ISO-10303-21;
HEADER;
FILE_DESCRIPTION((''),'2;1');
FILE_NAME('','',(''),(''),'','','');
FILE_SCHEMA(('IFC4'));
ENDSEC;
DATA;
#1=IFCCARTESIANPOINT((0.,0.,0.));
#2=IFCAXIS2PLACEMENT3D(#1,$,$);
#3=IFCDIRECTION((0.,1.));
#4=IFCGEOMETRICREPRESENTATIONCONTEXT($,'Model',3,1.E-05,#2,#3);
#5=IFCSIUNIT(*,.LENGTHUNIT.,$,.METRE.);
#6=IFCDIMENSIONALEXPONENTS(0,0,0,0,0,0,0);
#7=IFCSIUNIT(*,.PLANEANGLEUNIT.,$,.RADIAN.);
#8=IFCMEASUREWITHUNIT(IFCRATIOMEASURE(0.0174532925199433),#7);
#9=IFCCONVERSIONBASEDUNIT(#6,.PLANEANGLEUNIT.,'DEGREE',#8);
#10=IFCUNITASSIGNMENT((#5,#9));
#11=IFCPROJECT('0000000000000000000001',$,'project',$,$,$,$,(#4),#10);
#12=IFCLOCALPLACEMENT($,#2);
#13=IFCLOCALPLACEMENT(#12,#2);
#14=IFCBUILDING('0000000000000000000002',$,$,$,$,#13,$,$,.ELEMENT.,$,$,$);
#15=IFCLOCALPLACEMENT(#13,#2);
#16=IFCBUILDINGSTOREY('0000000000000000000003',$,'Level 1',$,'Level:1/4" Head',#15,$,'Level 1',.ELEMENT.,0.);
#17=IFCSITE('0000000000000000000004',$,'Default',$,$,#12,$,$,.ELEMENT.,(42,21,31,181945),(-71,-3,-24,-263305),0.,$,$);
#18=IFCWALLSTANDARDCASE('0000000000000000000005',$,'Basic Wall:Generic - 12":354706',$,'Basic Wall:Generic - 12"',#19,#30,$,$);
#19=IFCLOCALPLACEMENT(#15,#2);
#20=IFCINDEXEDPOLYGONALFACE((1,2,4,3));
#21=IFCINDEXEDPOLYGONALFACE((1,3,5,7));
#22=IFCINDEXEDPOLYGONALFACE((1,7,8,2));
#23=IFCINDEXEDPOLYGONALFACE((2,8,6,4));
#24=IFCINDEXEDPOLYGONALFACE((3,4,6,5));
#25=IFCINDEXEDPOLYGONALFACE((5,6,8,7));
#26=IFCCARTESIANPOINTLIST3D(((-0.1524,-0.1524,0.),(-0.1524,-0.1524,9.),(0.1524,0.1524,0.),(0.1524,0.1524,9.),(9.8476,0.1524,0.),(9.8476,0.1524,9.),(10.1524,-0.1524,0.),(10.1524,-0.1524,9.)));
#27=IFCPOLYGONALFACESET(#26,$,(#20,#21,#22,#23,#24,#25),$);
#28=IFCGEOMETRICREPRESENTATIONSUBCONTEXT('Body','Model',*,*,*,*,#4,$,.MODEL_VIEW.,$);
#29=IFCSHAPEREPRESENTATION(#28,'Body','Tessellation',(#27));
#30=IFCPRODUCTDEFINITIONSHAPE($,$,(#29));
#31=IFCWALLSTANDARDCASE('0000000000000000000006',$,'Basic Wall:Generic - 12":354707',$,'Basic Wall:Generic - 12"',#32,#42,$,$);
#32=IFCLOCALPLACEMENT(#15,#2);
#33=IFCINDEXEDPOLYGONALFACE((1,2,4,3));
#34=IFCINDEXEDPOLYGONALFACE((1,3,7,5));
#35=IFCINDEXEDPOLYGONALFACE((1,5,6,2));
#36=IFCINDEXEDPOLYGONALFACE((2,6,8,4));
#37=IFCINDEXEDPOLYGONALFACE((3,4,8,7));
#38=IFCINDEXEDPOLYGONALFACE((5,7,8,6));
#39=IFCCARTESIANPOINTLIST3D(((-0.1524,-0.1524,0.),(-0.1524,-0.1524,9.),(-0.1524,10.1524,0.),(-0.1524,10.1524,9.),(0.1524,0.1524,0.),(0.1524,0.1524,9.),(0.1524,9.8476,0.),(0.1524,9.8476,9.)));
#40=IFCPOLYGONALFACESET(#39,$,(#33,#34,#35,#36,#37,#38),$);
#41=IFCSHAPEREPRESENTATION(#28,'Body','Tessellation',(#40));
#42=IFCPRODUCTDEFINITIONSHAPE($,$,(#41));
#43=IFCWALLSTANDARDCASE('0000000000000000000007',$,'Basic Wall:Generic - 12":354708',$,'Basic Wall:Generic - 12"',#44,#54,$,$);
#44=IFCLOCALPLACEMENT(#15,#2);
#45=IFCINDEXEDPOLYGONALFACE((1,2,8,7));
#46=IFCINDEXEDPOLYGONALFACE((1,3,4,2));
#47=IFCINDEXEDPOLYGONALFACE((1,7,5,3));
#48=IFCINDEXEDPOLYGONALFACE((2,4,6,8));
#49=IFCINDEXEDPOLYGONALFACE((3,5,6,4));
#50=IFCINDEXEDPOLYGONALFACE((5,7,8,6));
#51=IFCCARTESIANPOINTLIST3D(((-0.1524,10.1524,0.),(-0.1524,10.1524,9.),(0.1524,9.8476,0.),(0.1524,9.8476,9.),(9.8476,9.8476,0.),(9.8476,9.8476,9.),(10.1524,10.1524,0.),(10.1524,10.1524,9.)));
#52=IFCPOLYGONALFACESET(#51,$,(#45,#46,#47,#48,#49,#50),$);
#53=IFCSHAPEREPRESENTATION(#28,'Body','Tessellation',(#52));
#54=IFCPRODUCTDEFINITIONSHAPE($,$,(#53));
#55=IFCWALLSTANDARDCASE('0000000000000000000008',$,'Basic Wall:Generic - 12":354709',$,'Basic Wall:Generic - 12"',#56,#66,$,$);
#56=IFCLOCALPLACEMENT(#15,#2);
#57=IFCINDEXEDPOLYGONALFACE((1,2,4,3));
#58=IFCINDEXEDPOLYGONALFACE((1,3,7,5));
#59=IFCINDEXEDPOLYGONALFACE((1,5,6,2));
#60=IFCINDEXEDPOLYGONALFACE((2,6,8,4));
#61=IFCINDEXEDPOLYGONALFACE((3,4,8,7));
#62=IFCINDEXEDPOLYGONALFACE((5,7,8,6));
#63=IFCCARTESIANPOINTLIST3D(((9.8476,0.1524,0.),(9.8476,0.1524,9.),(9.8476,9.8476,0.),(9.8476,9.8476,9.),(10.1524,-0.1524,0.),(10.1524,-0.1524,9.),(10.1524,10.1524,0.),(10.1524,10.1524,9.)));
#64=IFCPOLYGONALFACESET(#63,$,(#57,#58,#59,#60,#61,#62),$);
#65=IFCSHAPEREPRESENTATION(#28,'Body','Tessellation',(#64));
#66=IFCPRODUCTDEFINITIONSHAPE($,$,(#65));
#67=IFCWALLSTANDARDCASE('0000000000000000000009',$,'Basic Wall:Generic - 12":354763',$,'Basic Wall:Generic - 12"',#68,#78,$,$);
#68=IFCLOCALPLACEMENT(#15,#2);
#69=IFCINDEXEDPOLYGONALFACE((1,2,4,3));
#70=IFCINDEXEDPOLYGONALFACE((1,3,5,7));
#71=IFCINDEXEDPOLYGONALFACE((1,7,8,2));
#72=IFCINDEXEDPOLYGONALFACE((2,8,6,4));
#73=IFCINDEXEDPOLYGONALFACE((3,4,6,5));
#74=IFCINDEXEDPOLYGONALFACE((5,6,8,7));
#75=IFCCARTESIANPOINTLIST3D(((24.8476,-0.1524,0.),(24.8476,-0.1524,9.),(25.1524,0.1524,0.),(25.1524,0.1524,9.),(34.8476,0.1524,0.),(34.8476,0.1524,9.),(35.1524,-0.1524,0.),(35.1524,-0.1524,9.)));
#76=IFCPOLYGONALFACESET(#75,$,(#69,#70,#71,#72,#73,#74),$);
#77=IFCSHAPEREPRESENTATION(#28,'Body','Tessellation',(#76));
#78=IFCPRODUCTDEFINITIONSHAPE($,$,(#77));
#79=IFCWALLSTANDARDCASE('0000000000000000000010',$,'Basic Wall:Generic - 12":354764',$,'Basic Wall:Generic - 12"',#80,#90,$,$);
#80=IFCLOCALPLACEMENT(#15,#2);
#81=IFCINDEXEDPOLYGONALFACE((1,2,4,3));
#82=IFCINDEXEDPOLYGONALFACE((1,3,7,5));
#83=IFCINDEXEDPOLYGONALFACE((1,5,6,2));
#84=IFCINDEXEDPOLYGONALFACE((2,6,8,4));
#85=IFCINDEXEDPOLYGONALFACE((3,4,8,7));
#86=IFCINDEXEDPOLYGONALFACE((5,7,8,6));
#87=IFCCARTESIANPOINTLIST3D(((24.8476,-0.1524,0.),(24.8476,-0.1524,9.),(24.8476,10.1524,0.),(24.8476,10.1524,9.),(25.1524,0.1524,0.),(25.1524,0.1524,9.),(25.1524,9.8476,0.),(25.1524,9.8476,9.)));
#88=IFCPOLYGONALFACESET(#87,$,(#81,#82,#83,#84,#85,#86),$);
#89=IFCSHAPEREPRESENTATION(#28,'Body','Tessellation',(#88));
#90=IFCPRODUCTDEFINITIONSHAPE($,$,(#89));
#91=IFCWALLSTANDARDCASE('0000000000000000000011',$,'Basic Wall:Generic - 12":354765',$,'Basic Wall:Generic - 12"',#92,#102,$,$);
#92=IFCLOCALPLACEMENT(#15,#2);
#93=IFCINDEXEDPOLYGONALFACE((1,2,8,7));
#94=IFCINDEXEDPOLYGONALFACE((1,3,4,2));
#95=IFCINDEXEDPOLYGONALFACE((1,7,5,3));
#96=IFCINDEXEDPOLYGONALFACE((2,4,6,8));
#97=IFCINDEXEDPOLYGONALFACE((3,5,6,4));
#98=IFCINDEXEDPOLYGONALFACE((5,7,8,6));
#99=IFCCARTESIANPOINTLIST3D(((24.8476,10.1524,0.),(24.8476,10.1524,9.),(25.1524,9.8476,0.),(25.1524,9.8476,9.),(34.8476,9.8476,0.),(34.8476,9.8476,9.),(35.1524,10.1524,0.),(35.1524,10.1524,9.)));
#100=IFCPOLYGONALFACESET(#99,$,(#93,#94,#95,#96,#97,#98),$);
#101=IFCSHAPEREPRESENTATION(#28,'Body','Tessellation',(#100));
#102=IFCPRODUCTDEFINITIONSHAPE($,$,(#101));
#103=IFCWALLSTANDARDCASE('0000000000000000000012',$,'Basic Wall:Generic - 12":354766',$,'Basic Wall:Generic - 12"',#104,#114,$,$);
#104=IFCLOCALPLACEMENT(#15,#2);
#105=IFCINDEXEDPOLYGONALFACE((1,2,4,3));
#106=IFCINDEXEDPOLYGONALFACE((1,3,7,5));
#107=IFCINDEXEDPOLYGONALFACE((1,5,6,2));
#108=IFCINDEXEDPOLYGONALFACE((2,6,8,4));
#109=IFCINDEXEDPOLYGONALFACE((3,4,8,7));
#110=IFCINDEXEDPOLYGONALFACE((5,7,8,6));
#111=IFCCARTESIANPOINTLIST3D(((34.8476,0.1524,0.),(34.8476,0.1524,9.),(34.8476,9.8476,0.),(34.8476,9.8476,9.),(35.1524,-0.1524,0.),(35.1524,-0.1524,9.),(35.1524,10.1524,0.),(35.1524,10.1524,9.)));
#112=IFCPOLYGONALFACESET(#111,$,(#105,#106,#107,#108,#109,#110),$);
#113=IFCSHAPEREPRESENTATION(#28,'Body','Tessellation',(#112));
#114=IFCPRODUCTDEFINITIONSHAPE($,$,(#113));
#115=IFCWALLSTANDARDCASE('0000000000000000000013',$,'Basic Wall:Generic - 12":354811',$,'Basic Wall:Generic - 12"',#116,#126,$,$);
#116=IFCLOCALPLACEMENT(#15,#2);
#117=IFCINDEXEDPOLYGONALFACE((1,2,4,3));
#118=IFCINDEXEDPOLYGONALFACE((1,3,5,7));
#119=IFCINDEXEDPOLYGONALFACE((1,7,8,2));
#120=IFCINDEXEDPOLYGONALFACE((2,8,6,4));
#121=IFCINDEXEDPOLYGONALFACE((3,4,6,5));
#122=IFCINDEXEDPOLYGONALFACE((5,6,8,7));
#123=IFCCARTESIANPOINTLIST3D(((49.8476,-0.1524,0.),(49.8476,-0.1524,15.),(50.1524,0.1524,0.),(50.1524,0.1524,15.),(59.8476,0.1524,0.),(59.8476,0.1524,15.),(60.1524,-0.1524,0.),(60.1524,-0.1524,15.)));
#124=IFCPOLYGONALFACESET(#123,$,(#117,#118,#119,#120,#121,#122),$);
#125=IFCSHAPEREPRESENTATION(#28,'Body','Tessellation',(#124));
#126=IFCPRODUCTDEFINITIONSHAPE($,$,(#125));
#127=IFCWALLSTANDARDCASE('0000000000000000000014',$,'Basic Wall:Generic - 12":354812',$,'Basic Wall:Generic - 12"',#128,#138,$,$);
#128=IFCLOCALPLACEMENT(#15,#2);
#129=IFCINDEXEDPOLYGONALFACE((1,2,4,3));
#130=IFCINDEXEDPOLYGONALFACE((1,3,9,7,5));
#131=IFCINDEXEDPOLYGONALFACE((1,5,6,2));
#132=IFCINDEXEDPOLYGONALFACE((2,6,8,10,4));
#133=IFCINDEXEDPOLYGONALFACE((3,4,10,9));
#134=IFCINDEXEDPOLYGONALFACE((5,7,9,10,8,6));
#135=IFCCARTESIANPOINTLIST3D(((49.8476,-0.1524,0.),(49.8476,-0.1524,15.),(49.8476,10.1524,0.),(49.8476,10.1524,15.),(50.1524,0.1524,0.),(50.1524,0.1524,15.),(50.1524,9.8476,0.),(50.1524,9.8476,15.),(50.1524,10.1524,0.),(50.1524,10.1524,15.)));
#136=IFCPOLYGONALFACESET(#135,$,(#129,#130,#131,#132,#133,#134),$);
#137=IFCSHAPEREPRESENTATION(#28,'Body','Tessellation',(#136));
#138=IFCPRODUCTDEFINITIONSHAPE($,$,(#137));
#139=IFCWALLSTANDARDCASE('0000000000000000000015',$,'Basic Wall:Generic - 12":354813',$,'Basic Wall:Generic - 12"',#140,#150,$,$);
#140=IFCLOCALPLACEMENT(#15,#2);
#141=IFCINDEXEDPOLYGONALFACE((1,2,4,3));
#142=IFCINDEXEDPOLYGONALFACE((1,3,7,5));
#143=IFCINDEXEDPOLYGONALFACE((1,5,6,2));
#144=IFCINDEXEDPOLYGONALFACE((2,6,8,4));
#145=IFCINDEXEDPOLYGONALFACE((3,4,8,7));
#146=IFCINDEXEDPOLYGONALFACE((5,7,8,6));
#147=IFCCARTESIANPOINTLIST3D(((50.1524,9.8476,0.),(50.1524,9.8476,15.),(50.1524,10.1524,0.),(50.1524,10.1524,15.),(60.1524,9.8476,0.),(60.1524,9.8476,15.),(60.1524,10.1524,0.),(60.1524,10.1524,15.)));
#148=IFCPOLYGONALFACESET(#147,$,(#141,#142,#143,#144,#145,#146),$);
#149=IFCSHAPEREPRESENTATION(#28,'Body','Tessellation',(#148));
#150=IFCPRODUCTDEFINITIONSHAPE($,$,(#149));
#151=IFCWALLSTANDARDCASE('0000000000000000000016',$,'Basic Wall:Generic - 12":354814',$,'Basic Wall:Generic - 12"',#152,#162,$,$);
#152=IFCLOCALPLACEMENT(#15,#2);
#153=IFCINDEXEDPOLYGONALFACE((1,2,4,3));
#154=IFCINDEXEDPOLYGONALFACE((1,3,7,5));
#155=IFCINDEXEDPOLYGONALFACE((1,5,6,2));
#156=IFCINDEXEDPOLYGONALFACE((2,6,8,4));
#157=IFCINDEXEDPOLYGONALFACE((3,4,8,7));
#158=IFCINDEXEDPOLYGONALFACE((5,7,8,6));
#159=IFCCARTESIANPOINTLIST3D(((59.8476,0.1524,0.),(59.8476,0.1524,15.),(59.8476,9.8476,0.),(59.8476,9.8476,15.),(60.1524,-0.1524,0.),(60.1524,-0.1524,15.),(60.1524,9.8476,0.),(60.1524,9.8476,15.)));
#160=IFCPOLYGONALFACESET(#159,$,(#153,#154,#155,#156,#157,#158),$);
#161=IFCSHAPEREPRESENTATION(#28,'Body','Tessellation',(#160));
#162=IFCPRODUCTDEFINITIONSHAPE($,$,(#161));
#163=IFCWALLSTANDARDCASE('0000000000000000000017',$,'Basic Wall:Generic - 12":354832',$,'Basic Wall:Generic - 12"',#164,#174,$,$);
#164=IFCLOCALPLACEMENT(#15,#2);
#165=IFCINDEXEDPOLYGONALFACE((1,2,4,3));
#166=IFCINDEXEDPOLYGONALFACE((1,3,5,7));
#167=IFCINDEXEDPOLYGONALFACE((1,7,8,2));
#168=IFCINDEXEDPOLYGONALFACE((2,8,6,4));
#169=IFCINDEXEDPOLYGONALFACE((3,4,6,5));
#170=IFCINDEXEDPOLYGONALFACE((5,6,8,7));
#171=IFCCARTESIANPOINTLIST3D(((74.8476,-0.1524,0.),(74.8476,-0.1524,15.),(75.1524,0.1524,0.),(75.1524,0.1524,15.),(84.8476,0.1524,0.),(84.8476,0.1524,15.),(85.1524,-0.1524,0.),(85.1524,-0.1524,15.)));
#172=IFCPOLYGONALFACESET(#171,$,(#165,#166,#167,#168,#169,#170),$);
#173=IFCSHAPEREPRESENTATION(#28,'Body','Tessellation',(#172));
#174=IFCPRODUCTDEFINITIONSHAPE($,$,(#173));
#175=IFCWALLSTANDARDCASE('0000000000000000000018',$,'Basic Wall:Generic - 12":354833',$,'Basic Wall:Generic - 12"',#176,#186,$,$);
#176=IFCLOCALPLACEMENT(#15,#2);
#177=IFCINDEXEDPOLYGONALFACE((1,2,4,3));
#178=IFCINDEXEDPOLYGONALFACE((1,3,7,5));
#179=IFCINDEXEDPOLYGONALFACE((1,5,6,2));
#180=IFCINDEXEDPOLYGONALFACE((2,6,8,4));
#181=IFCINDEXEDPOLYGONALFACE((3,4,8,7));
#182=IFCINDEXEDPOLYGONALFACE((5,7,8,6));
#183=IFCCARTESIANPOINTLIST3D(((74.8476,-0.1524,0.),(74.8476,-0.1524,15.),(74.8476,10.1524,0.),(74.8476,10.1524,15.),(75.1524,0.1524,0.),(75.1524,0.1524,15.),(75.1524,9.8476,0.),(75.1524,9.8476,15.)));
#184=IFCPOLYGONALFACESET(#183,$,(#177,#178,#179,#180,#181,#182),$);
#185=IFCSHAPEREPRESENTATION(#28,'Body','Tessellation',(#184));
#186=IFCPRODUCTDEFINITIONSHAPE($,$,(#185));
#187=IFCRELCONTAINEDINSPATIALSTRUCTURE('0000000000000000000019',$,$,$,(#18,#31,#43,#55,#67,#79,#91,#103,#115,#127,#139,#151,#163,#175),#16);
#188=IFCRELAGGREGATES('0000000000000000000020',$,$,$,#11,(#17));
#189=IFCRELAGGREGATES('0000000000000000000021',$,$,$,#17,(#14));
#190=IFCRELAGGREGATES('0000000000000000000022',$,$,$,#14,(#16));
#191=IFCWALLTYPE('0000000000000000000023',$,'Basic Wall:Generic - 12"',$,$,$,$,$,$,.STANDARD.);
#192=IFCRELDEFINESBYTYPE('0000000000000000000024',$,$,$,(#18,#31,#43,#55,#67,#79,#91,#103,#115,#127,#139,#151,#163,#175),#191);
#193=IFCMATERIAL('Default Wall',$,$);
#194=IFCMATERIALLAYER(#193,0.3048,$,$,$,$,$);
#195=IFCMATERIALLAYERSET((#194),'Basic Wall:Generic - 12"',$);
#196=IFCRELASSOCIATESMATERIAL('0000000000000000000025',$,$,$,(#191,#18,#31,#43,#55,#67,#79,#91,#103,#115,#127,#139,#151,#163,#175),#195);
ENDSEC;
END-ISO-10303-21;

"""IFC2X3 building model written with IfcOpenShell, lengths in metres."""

from ifc_helpers import new_model, entity, si_unit, converted_unit, direction, frame, frame_2d, origin, place, context, subcontext, project, spatial, polyline, rectangle, outline, extrude, material, layer, layer_set, layer_usage, type_object, element, save


model = new_model("IFC2X3")

# Units and contexts
model_context = context("Model", 3, precision=1e-05, world=origin(), true_north=direction((0.0, 1.0)))
body_context = subcontext(model_context, "Body", "Model", "MODEL_VIEW")
ifc_project = project(units=[si_unit("LENGTHUNIT", "METRE"), converted_unit("PLANEANGLEUNIT", "DEGREE", entity("IfcRatioMeasure", 0.0174532925199433), si_unit("PLANEANGLEUNIT", "RADIAN"), dimensions=[0, 0, 0, 0, 0, 0, 0])], contexts=[model_context])

# Site, building, storey
site_placement = place(None, origin())
site = spatial("IfcSite", under=ifc_project, at=site_placement, Name="Default", CompositionType="ELEMENT", RefLatitude=(42, 21, 31, 181945), RefLongitude=(-71, -3, -24, -263305), RefElevation=0.0)
building_placement = place(site_placement, origin())
building = spatial("IfcBuilding", under=site, at=building_placement, CompositionType="ELEMENT")
storey_placement = place(building_placement, origin())
storey = spatial("IfcBuildingStorey", under=building, at=storey_placement, Name="Level 1", ObjectType="Level:1/4\" Head", LongName="Level 1", CompositionType="ELEMENT", Elevation=0.0)

# Walls
ifc_material = material(Name="Default Wall")
ifc_layer = layer(ifc_material, 0.3048)
ifc_layer_set = layer_set([ifc_layer], Name="Basic Wall:Generic - 12\"")
ifc_layer_usage_1 = layer_usage(ifc_layer_set, "AXIS2", "NEGATIVE", 0.1524)
wall_type = type_object("IfcWallType", Name="Basic Wall:Generic - 12\"", PredefinedType="STANDARD", material=ifc_layer_set)
wall_1_placement = place(storey_placement, frame((-0.1524, 0.0, 0.0)))
element("IfcWallStandardCase", 1, at=wall_1_placement, inside=storey, type_object=wall_type, material=ifc_layer_usage_1, Name="Basic Wall:Generic - 12\":354706", ObjectType="Basic Wall:Generic - 12\"", context=body_context, shape_type="SweptSolid", body=[
    extrude(outline(polyline([(10.3048, -0.1524), (10.0, 0.1524), (0.3048, 0.1524), (0.0, -0.1524), (10.3048, -0.1524)])), origin(), (0.0, 0.0, 1.0), 9.0),
])
ifc_layer_usage_2 = layer_usage(ifc_layer_set, "AXIS2", "NEGATIVE", 0.1524)
wall_2_placement = place(storey_placement, frame((0.0, 10.1524, 0.0), z_axis=(0.0, 0.0, 1.0), x_axis=(0.0, -1.0, 0.0)))
element("IfcWallStandardCase", 2, at=wall_2_placement, inside=storey, type_object=wall_type, material=ifc_layer_usage_2, Name="Basic Wall:Generic - 12\":354707", ObjectType="Basic Wall:Generic - 12\"", context=body_context, shape_type="SweptSolid", body=[
    extrude(outline(polyline([(10.3048, -0.1524), (10.0, 0.1524), (0.3048, 0.1524), (0.0, -0.1524), (10.3048, -0.1524)])), origin(), (0.0, 0.0, 1.0), 9.0),
])
ifc_layer_usage_3 = layer_usage(ifc_layer_set, "AXIS2", "NEGATIVE", 0.1524)
wall_3_placement = place(storey_placement, frame((10.1524, 10.0, 0.0), z_axis=(0.0, 0.0, 1.0), x_axis=(-1.0, 0.0, 0.0)))
element("IfcWallStandardCase", 3, at=wall_3_placement, inside=storey, type_object=wall_type, material=ifc_layer_usage_3, Name="Basic Wall:Generic - 12\":354708", ObjectType="Basic Wall:Generic - 12\"", context=body_context, shape_type="SweptSolid", body=[
    extrude(outline(polyline([(10.3048, -0.1524), (10.0, 0.1524), (0.3048, 0.1524), (0.0, -0.1524), (10.3048, -0.1524)])), origin(), (0.0, 0.0, 1.0), 9.0),
])
ifc_layer_usage_4 = layer_usage(ifc_layer_set, "AXIS2", "NEGATIVE", 0.1524)
wall_4_placement = place(storey_placement, frame((10.0, -0.1524, 0.0), z_axis=(0.0, 0.0, 1.0), x_axis=(0.0, 1.0, 0.0)))
element("IfcWallStandardCase", 4, at=wall_4_placement, inside=storey, type_object=wall_type, material=ifc_layer_usage_4, Name="Basic Wall:Generic - 12\":354709", ObjectType="Basic Wall:Generic - 12\"", context=body_context, shape_type="SweptSolid", body=[
    extrude(outline(polyline([(10.3048, -0.1524), (10.0, 0.1524), (0.3048, 0.1524), (0.0, -0.1524), (10.3048, -0.1524)])), origin(), (0.0, 0.0, 1.0), 9.0),
])
ifc_layer_usage_5 = layer_usage(ifc_layer_set, "AXIS2", "NEGATIVE", 0.1524)
wall_5_placement = place(storey_placement, frame((24.8476, 0.0, 0.0)))
element("IfcWallStandardCase", 5, at=wall_5_placement, inside=storey, type_object=wall_type, material=ifc_layer_usage_5, Name="Basic Wall:Generic - 12\":354763", ObjectType="Basic Wall:Generic - 12\"", context=body_context, shape_type="SweptSolid", body=[
    extrude(outline(polyline([(10.3048, -0.1524), (10.0, 0.1524), (0.3048, 0.1524), (0.0, -0.1524), (10.3048, -0.1524)])), origin(), (0.0, 0.0, 1.0), 9.0),
])
ifc_layer_usage_6 = layer_usage(ifc_layer_set, "AXIS2", "NEGATIVE", 0.1524)
wall_6_placement = place(storey_placement, frame((25.0, 10.1524, 0.0), z_axis=(0.0, 0.0, 1.0), x_axis=(0.0, -1.0, 0.0)))
element("IfcWallStandardCase", 6, at=wall_6_placement, inside=storey, type_object=wall_type, material=ifc_layer_usage_6, Name="Basic Wall:Generic - 12\":354764", ObjectType="Basic Wall:Generic - 12\"", context=body_context, shape_type="SweptSolid", body=[
    extrude(outline(polyline([(10.3048, -0.1524), (10.0, 0.1524), (0.3048, 0.1524), (0.0, -0.1524), (10.3048, -0.1524)])), origin(), (0.0, 0.0, 1.0), 9.0),
])
ifc_layer_usage_7 = layer_usage(ifc_layer_set, "AXIS2", "NEGATIVE", 0.1524)
wall_7_placement = place(storey_placement, frame((35.1524, 10.0, 0.0), z_axis=(0.0, 0.0, 1.0), x_axis=(-1.0, 0.0, 0.0)))
element("IfcWallStandardCase", 7, at=wall_7_placement, inside=storey, type_object=wall_type, material=ifc_layer_usage_7, Name="Basic Wall:Generic - 12\":354765", ObjectType="Basic Wall:Generic - 12\"", context=body_context, shape_type="SweptSolid", body=[
    extrude(outline(polyline([(10.3048, -0.1524), (10.0, 0.1524), (0.3048, 0.1524), (0.0, -0.1524), (10.3048, -0.1524)])), origin(), (0.0, 0.0, 1.0), 9.0),
])
ifc_layer_usage_8 = layer_usage(ifc_layer_set, "AXIS2", "NEGATIVE", 0.1524)
wall_8_placement = place(storey_placement, frame((35.0, -0.1524, 0.0), z_axis=(0.0, 0.0, 1.0), x_axis=(0.0, 1.0, 0.0)))
element("IfcWallStandardCase", 8, at=wall_8_placement, inside=storey, type_object=wall_type, material=ifc_layer_usage_8, Name="Basic Wall:Generic - 12\":354766", ObjectType="Basic Wall:Generic - 12\"", context=body_context, shape_type="SweptSolid", body=[
    extrude(outline(polyline([(10.3048, -0.1524), (10.0, 0.1524), (0.3048, 0.1524), (0.0, -0.1524), (10.3048, -0.1524)])), origin(), (0.0, 0.0, 1.0), 9.0),
])
ifc_layer_usage_9 = layer_usage(ifc_layer_set, "AXIS2", "NEGATIVE", 0.1524)
wall_9_placement = place(storey_placement, frame((49.8476, 0.0, 0.0)))
element("IfcWallStandardCase", 9, at=wall_9_placement, inside=storey, type_object=wall_type, material=ifc_layer_usage_9, Name="Basic Wall:Generic - 12\":354811", ObjectType="Basic Wall:Generic - 12\"", context=body_context, shape_type="SweptSolid", body=[
    extrude(outline(polyline([(10.3048, -0.1524), (10.0, 0.1524), (0.3048, 0.1524), (0.0, -0.1524), (10.3048, -0.1524)])), origin(), (0.0, 0.0, 1.0), 15.0),
])
ifc_layer_usage_10 = layer_usage(ifc_layer_set, "AXIS2", "NEGATIVE", 0.1524)
wall_10_placement = place(storey_placement, frame((50.0, 10.1524, 0.0), z_axis=(0.0, 0.0, 1.0), x_axis=(0.0, -1.0, 0.0)))
element("IfcWallStandardCase", 10, at=wall_10_placement, inside=storey, type_object=wall_type, material=ifc_layer_usage_10, Name="Basic Wall:Generic - 12\":354812", ObjectType="Basic Wall:Generic - 12\"", context=body_context, shape_type="SweptSolid", body=[
    extrude(outline(polyline([(10.3048, -0.1524), (10.0, 0.1524), (0.3048, 0.1524), (0.0, 0.1524), (0.0, -0.1524), (10.3048, -0.1524)])), origin(), (0.0, 0.0, 1.0), 15.0),
])
ifc_layer_usage_11 = layer_usage(ifc_layer_set, "AXIS2", "NEGATIVE", 0.1524)
wall_11_placement = place(storey_placement, frame((60.1524, 10.0, 0.0), z_axis=(0.0, 0.0, 1.0), x_axis=(-1.0, 0.0, 0.0)))
element("IfcWallStandardCase", 11, at=wall_11_placement, inside=storey, type_object=wall_type, material=ifc_layer_usage_11, Name="Basic Wall:Generic - 12\":354813", ObjectType="Basic Wall:Generic - 12\"", context=body_context, shape_type="SweptSolid", body=[
    extrude(rectangle(XDim=10.0, YDim=0.3048, at=frame_2d((5.0, 0.0), x_axis=(-1.0, 0.0))), origin(), (0.0, 0.0, 1.0), 15.0),
])
ifc_layer_usage_12 = layer_usage(ifc_layer_set, "AXIS2", "NEGATIVE", 0.1524)
wall_12_placement = place(storey_placement, frame((60.0, -0.1524, 0.0), z_axis=(0.0, 0.0, 1.0), x_axis=(0.0, 1.0, 0.0)))
element("IfcWallStandardCase", 12, at=wall_12_placement, inside=storey, type_object=wall_type, material=ifc_layer_usage_12, Name="Basic Wall:Generic - 12\":354814", ObjectType="Basic Wall:Generic - 12\"", context=body_context, shape_type="SweptSolid", body=[
    extrude(outline(polyline([(10.0, -0.1524), (10.0, 0.1524), (0.3048, 0.1524), (0.0, -0.1524), (10.0, -0.1524)])), origin(), (0.0, 0.0, 1.0), 15.0),
])
ifc_layer_usage_13 = layer_usage(ifc_layer_set, "AXIS2", "NEGATIVE", 0.1524)
wall_13_placement = place(storey_placement, frame((74.8476, 0.0, 0.0)))
element("IfcWallStandardCase", 13, at=wall_13_placement, inside=storey, type_object=wall_type, material=ifc_layer_usage_13, Name="Basic Wall:Generic - 12\":354832", ObjectType="Basic Wall:Generic - 12\"", context=body_context, shape_type="SweptSolid", body=[
    extrude(outline(polyline([(10.3048, -0.1524), (10.0, 0.1524), (0.3048, 0.1524), (0.0, -0.1524), (10.3048, -0.1524)])), origin(), (0.0, 0.0, 1.0), 15.0),
])
ifc_layer_usage_14 = layer_usage(ifc_layer_set, "AXIS2", "NEGATIVE", 0.1524)
wall_14_placement = place(storey_placement, frame((75.0, 10.1524, 0.0), z_axis=(0.0, 0.0, 1.0), x_axis=(0.0, -1.0, 0.0)))
element("IfcWallStandardCase", 14, at=wall_14_placement, inside=storey, type_object=wall_type, material=ifc_layer_usage_14, Name="Basic Wall:Generic - 12\":354833", ObjectType="Basic Wall:Generic - 12\"", context=body_context, shape_type="SweptSolid", body=[
    extrude(outline(polyline([(10.3048, -0.1524), (10.0, 0.1524), (0.3048, 0.1524), (0.0, -0.1524), (10.3048, -0.1524)])), origin(), (0.0, 0.0, 1.0), 15.0),
])

save(model, "model.ifc")
